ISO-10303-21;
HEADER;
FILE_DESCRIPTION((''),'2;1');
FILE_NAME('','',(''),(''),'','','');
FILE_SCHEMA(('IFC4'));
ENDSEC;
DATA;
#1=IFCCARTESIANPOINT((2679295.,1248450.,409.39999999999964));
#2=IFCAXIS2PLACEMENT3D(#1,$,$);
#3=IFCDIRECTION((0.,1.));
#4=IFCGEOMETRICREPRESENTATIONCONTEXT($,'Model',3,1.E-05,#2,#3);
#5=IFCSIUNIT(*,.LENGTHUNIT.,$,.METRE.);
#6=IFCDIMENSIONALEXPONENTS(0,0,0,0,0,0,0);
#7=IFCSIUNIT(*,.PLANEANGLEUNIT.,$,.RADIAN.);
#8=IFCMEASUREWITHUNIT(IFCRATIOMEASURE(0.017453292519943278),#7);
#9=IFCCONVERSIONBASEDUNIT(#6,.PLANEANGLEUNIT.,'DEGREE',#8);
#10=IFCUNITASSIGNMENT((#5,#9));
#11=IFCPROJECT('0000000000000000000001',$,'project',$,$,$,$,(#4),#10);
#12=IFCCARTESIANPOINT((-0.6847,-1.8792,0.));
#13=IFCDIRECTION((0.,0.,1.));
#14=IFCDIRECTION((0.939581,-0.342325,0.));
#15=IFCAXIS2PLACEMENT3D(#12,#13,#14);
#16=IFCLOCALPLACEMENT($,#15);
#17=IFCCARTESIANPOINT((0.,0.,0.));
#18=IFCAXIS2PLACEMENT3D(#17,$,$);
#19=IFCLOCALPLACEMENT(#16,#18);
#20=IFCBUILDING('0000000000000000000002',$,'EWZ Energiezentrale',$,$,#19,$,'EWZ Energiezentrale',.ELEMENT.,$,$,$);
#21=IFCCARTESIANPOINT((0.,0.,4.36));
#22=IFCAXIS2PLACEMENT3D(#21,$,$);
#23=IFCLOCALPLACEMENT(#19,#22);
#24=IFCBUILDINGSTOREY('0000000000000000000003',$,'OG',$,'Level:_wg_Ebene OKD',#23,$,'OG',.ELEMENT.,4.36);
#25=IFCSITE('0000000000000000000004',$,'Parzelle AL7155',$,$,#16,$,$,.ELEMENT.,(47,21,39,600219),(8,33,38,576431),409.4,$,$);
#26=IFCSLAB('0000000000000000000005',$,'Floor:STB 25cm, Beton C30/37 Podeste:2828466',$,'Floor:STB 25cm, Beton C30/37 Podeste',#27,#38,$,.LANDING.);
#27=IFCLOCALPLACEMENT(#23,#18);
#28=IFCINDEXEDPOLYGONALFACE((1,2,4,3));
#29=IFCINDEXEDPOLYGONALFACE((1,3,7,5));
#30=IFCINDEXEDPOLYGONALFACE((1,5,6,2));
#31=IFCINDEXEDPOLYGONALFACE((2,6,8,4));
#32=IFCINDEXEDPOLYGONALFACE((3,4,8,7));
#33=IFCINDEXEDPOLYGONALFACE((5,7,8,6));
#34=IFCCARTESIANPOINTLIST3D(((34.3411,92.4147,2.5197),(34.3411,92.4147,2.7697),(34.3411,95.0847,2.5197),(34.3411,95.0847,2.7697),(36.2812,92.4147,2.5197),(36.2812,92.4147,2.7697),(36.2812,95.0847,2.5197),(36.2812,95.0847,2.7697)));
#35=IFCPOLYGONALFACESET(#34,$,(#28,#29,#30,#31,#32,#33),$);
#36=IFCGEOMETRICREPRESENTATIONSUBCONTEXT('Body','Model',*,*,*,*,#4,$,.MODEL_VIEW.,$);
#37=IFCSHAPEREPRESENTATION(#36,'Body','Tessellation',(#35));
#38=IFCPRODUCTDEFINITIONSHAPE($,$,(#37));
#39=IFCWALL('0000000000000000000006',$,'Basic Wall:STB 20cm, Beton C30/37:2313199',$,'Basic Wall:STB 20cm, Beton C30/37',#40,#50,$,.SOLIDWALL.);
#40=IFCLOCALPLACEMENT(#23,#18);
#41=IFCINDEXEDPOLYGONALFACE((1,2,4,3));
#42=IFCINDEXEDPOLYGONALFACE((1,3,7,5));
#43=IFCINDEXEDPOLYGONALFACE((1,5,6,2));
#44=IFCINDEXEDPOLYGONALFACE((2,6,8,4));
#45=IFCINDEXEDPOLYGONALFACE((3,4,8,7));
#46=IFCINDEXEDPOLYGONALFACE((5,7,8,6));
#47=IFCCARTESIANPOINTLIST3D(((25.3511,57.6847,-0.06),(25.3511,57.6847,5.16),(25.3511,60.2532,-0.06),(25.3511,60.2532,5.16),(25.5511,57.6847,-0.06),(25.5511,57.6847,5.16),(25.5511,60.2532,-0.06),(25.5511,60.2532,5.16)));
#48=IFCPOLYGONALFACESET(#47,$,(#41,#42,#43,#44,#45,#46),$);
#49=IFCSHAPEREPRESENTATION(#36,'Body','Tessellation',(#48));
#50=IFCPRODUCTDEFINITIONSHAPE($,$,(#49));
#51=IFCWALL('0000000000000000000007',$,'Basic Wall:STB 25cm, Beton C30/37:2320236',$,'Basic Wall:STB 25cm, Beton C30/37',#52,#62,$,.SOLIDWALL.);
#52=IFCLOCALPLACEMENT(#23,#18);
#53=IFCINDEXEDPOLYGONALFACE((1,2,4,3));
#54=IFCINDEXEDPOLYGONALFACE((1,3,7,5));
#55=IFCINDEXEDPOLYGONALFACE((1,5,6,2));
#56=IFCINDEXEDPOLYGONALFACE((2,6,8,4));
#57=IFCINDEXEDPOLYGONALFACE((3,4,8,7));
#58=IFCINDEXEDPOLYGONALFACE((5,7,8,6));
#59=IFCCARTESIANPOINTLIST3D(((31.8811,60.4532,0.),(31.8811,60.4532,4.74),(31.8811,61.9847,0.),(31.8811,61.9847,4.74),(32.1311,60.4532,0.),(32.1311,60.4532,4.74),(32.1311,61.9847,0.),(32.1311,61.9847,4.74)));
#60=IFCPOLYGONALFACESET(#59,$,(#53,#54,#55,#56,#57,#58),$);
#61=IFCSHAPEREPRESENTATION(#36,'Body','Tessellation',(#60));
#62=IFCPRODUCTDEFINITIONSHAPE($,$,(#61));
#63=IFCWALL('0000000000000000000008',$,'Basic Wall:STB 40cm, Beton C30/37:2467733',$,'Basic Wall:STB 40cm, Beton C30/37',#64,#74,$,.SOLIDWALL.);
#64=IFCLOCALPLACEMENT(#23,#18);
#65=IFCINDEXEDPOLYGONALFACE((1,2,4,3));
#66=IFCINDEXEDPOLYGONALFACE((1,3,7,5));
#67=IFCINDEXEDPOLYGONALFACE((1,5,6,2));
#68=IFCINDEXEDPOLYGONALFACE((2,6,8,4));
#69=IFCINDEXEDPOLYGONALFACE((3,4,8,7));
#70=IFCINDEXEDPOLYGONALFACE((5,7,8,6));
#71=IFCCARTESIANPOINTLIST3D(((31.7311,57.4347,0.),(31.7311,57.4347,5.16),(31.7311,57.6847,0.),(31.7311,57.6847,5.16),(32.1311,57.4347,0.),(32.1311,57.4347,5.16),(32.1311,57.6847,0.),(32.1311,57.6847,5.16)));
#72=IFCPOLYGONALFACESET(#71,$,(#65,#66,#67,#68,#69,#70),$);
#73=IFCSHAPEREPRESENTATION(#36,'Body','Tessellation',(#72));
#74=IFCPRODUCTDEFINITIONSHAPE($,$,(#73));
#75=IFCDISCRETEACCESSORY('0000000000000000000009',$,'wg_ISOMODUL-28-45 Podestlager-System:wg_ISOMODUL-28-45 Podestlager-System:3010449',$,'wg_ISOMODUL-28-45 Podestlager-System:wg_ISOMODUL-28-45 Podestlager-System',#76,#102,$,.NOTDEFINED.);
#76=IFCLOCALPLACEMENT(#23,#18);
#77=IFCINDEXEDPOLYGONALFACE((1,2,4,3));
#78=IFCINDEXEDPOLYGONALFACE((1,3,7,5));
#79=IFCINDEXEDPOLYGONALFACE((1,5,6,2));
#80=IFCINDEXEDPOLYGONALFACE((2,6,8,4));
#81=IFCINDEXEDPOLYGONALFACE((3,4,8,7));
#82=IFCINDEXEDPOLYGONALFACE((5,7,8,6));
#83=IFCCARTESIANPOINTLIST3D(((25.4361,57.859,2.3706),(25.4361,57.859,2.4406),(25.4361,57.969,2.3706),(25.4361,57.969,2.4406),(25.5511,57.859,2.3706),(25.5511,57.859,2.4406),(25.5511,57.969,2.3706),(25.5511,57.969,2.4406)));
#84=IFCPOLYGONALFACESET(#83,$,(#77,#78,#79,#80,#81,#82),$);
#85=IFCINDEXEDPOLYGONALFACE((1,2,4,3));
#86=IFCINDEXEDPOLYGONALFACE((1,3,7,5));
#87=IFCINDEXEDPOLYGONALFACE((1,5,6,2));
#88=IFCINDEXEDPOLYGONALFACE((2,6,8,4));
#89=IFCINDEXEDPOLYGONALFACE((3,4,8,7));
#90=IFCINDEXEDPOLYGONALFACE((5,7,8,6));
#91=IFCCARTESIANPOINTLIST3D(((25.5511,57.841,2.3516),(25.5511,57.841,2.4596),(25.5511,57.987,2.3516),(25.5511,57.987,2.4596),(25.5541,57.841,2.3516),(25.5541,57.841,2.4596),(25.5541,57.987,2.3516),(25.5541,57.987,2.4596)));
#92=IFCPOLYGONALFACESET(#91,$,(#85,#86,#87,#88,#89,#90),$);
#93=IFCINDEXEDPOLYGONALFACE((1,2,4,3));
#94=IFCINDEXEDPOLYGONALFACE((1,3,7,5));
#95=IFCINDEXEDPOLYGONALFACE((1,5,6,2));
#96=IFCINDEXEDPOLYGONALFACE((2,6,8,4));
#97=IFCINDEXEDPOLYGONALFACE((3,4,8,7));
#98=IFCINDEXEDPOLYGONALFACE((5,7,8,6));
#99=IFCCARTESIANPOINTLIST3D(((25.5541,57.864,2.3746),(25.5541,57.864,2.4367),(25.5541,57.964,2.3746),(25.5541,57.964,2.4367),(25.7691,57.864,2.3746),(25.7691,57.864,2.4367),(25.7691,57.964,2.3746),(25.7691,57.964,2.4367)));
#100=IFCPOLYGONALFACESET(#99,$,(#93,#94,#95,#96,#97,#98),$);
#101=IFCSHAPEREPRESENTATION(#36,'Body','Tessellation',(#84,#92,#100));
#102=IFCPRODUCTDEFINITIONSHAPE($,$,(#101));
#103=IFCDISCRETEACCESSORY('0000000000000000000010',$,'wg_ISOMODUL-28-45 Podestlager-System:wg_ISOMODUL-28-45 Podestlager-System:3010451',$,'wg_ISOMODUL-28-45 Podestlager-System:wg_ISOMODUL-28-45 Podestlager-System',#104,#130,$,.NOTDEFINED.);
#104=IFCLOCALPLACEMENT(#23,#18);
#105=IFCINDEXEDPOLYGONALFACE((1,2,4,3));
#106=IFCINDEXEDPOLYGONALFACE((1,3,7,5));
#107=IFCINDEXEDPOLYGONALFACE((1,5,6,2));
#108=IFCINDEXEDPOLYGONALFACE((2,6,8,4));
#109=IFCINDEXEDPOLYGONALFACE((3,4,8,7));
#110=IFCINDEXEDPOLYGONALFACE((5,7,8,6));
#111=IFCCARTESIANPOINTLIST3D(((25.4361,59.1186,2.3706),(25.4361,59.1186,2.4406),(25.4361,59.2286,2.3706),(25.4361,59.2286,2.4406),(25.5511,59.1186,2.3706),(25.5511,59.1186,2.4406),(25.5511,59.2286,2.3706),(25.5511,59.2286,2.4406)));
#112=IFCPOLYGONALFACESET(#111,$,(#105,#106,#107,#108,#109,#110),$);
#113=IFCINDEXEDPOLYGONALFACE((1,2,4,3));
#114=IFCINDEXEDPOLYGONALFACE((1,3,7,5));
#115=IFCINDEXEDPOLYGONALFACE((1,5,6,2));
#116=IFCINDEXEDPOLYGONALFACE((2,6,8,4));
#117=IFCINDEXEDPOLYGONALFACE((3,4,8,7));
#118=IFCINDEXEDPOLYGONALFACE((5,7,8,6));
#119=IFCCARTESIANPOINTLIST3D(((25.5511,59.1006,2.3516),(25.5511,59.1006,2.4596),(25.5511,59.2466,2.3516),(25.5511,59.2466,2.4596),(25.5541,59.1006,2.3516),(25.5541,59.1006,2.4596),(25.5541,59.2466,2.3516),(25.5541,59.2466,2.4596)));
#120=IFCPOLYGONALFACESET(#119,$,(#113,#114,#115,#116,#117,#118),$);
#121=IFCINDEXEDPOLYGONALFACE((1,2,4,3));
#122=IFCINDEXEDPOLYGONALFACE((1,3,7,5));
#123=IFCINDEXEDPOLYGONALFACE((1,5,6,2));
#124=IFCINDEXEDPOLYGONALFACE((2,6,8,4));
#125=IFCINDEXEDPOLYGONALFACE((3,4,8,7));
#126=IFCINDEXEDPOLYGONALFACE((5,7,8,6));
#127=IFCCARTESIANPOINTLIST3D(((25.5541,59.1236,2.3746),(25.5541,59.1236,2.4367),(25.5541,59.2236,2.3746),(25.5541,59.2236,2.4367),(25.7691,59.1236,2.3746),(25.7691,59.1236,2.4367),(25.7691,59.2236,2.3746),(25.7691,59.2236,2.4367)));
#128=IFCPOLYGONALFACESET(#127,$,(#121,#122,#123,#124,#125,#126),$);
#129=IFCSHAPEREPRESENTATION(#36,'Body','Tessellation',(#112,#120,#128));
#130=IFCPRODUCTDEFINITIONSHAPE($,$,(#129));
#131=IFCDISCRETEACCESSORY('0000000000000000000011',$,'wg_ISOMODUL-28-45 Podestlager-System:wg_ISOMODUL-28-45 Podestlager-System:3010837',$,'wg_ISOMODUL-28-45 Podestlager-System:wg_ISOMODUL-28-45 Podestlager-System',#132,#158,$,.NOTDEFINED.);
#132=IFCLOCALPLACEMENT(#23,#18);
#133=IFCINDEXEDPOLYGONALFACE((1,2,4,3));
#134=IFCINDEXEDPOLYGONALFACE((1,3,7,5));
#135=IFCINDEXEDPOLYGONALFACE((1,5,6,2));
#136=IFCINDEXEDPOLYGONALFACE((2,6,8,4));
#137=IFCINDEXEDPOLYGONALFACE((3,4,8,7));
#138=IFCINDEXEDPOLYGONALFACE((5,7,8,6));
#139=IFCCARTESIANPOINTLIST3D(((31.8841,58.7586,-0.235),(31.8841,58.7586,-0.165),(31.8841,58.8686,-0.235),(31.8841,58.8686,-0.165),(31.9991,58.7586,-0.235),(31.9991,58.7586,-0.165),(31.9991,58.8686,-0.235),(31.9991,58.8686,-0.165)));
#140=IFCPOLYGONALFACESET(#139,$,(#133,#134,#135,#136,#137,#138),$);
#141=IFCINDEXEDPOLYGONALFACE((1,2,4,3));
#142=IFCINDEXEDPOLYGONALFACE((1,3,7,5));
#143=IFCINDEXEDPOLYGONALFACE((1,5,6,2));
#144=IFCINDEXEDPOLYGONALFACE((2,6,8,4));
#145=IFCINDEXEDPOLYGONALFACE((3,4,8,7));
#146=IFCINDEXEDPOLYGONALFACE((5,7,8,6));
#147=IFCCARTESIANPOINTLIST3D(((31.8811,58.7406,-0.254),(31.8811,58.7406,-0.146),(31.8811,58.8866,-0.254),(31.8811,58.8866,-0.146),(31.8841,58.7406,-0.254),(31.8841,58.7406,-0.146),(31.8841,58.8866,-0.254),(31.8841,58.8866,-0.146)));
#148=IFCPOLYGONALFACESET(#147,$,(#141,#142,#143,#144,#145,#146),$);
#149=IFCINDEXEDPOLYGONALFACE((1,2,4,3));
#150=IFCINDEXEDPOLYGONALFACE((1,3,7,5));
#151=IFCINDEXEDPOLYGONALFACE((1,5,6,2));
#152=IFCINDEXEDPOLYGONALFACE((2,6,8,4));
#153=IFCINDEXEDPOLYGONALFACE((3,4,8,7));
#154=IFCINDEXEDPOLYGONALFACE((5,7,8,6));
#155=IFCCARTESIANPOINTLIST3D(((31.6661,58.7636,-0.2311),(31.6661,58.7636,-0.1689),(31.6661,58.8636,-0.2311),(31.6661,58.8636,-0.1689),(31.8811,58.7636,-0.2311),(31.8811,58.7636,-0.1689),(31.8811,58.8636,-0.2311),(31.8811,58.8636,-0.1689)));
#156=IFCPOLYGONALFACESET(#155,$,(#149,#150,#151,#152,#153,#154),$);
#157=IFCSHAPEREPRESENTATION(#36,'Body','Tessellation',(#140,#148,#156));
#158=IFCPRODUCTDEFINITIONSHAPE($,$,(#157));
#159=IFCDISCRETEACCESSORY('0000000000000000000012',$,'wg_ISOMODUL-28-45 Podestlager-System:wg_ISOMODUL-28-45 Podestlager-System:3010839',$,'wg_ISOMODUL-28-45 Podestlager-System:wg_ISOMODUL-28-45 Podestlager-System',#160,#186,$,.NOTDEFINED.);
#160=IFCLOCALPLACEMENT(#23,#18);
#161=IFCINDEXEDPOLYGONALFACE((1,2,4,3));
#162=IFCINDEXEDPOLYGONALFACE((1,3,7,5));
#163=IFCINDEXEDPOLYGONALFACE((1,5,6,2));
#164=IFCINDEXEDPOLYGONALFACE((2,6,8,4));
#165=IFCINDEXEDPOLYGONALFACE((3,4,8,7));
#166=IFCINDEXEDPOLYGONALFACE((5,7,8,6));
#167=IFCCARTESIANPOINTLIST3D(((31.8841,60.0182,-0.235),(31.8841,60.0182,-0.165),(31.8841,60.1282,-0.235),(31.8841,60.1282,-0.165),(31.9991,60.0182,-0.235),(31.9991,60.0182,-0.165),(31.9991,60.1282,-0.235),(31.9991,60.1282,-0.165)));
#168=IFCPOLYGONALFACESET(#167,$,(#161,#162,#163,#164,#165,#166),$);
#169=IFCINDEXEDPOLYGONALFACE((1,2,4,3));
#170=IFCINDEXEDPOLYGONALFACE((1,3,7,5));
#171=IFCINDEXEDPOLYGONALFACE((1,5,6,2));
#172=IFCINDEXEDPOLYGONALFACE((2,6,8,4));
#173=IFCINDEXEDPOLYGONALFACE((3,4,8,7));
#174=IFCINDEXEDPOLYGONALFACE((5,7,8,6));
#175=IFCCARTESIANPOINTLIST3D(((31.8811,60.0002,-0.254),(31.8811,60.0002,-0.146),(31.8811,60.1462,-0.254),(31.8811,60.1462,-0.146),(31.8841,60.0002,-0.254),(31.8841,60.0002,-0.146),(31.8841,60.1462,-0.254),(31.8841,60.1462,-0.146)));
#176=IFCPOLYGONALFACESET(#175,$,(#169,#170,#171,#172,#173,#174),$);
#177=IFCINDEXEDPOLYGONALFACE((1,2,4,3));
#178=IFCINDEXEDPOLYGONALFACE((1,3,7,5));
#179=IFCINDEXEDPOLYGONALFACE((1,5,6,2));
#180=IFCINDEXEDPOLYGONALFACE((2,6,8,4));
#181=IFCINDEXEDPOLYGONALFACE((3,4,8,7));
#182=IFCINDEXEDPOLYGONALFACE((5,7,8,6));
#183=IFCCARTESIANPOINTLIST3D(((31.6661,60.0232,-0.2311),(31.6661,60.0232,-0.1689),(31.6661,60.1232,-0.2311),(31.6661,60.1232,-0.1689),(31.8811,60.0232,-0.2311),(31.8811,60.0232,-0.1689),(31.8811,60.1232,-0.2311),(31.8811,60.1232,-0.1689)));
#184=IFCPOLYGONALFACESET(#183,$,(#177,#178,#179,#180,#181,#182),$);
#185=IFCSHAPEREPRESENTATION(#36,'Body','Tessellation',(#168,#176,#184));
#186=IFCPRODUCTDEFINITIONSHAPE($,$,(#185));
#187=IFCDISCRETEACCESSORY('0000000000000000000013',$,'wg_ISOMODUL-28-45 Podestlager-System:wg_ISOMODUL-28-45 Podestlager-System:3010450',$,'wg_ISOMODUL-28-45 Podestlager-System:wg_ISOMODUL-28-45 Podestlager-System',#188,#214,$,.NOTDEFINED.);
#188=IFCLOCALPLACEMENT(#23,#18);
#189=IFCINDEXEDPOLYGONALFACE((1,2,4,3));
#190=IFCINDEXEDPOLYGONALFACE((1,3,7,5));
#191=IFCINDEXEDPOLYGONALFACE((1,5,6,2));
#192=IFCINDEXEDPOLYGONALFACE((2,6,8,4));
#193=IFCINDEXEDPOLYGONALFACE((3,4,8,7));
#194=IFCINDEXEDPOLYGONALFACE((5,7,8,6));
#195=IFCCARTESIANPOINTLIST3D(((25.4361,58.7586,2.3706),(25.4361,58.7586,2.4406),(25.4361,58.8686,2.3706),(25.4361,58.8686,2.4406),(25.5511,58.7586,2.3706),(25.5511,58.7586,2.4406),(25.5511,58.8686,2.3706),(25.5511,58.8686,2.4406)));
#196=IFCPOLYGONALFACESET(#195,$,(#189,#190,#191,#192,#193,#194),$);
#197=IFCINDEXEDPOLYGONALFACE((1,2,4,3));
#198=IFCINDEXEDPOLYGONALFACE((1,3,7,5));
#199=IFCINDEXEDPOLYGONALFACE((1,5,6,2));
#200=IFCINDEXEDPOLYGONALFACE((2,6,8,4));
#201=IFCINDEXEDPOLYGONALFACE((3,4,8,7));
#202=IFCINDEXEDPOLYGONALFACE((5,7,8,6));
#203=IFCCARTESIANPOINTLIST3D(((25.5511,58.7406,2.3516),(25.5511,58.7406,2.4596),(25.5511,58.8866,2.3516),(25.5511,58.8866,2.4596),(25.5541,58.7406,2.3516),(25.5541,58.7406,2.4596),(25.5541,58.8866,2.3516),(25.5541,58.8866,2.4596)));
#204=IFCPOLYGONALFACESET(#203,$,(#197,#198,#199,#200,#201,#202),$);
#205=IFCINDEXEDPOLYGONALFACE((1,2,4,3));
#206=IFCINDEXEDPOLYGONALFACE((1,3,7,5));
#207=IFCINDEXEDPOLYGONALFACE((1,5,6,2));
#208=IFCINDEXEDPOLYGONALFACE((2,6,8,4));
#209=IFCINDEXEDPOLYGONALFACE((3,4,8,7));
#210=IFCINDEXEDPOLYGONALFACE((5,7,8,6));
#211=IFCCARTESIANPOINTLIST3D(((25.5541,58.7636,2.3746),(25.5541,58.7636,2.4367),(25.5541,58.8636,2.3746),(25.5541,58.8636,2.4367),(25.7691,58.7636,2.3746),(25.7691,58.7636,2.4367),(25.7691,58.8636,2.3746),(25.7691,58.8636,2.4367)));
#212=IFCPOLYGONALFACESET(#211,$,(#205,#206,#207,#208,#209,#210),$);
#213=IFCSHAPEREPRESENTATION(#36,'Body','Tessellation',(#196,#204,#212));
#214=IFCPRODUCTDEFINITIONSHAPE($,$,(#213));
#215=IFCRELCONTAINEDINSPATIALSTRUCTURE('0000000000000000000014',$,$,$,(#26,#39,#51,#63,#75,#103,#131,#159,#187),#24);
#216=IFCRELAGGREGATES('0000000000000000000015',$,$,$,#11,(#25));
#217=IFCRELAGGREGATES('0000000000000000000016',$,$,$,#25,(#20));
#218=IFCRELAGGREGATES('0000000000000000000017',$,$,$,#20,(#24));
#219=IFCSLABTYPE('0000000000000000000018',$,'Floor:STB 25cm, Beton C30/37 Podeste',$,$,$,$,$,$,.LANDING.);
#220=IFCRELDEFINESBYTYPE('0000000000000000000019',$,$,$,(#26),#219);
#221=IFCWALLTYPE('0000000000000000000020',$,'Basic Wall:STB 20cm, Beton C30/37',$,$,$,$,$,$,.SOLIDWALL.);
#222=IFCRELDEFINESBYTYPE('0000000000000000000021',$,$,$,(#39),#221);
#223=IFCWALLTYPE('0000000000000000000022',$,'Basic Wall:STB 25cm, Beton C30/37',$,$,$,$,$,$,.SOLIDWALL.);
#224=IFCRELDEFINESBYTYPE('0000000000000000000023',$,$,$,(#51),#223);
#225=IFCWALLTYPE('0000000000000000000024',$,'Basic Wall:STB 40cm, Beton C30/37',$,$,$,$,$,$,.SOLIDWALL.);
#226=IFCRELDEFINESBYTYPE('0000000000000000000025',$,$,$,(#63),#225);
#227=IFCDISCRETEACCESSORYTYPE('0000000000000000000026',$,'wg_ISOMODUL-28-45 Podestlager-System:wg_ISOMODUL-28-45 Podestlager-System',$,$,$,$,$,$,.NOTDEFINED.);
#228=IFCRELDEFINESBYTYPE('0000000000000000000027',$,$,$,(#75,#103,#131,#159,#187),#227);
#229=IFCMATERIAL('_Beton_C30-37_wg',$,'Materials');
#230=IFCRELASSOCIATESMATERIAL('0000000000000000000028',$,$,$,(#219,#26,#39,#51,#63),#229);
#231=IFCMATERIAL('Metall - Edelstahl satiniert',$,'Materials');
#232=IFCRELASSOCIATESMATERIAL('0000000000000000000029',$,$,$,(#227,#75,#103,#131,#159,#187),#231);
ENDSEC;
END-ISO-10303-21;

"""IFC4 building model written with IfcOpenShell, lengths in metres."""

from ifc_helpers import new_model, entity, si_unit, converted_unit, direction, frame, origin, place, context, subcontext, project, spatial, indexed_curve, outline, extrude, source, transform, mapped, material, type_object, type_shapes, element, save


model = new_model("IFC4")

# Units and contexts
model_context = context("Model", 3, precision=1e-05, world=frame((2679295.0, 1248450.0, 409.39999999999964)), true_north=direction((0.0, 1.0)))
body_context = subcontext(model_context, "Body", "Model", "MODEL_VIEW")
ifc_project = project(units=[si_unit("LENGTHUNIT", "METRE"), converted_unit("PLANEANGLEUNIT", "DEGREE", entity("IfcRatioMeasure", 0.017453292519943278), si_unit("PLANEANGLEUNIT", "RADIAN"), dimensions=[0, 0, 0, 0, 0, 0, 0])], contexts=[model_context])

# Site, building, storey
site_placement = place(None, frame((-0.6847, -1.8792, 0.0), z_axis=(0.0, 0.0, 1.0), x_axis=(0.939581, -0.342325, 0.0)))
site = spatial("IfcSite", under=ifc_project, at=site_placement, Name="Parzelle AL7155", CompositionType="ELEMENT", RefLatitude=(47, 21, 39, 600219), RefLongitude=(8, 33, 38, 576431), RefElevation=409.4)
building_placement = place(site_placement, origin())
building = spatial("IfcBuilding", under=site, at=building_placement, Name="EWZ Energiezentrale", LongName="EWZ Energiezentrale", CompositionType="ELEMENT")
storey_placement = place(building_placement, frame((0.0, 0.0, 4.36)))
storey = spatial("IfcBuildingStorey", under=building, at=storey_placement, Name="OG", ObjectType="Level:_wg_Ebene OKD", LongName="OG", CompositionType="ELEMENT", Elevation=4.36)

# Slab
ifc_material_1 = material(Name="_Beton_C30-37_wg", Category="Materials")
slab_type = type_object("IfcSlabType", Name="Floor:STB 25cm, Beton C30/37 Podeste", PredefinedType="LANDING", material=ifc_material_1)
slab_placement = place(storey_placement, frame((0.0, 0.0, 0.0), z_axis=(0.0, 0.0, 1.0), x_axis=(1.0, 0.0, 0.0)))
element("IfcSlab", 1, at=slab_placement, inside=storey, type_object=slab_type, material=ifc_material_1, Name="Floor:STB 25cm, Beton C30/37 Podeste:2828466", ObjectType="Floor:STB 25cm, Beton C30/37 Podeste", PredefinedType="LANDING", context=body_context, shape_type="SweptSolid", body=[
    extrude(outline(indexed_curve([(-1.335, -0.9701), (1.335, -0.9701), (1.335, 0.9701), (-1.335, 0.9701), (-1.335, -0.9701)], self_intersect=False)), frame((35.3111, 93.7497, 2.7697), z_axis=(0.0, 0.0, -1.0), x_axis=(0.0, 1.0, 0.0)), (0.0, 0.0, 1.0), 0.25),
])

# Walls
wall_type_1 = type_object("IfcWallType", Name="Basic Wall:STB 20cm, Beton C30/37", PredefinedType="SOLIDWALL")
wall_1_placement = place(storey_placement, frame((25.4511, 57.6847, -0.06), z_axis=(0.0, 0.0, 1.0), x_axis=(0.0, 1.0, 0.0)))
element("IfcWall", 2, at=wall_1_placement, inside=storey, type_object=wall_type_1, material=ifc_material_1, Name="Basic Wall:STB 20cm, Beton C30/37:2313199", ObjectType="Basic Wall:STB 20cm, Beton C30/37", PredefinedType="SOLIDWALL", context=body_context, shape_type="SweptSolid", body=[
    extrude(outline(indexed_curve([(2.5686, 0.1), (0.0, 0.1), (0.0, -0.1), (2.5686, -0.1), (2.5686, 0.1)], self_intersect=False)), origin(), (0.0, 0.0, 1.0), 5.22),
])
wall_type_2 = type_object("IfcWallType", Name="Basic Wall:STB 25cm, Beton C30/37", PredefinedType="SOLIDWALL")
wall_2_placement = place(storey_placement, frame((32.0061, 60.4532, 0.0), z_axis=(0.0, 0.0, 1.0), x_axis=(0.0, 1.0, 0.0)))
element("IfcWall", 3, at=wall_2_placement, inside=storey, type_object=wall_type_2, material=ifc_material_1, Name="Basic Wall:STB 25cm, Beton C30/37:2320236", ObjectType="Basic Wall:STB 25cm, Beton C30/37", PredefinedType="SOLIDWALL", context=body_context, shape_type="SweptSolid", body=[
    extrude(outline(indexed_curve([(1.5314, 0.125), (0.0, 0.125), (0.0, -0.125), (1.5314, -0.125), (1.5314, 0.125)], self_intersect=False)), origin(), (0.0, 0.0, 1.0), 4.74),
])
wall_type_3 = type_object("IfcWallType", Name="Basic Wall:STB 40cm, Beton C30/37", PredefinedType="SOLIDWALL")
wall_3_placement = place(storey_placement, frame((31.9311, 57.4347, 0.0), z_axis=(0.0, 0.0, 1.0), x_axis=(0.0, 1.0, 0.0)))
element("IfcWall", 4, at=wall_3_placement, inside=storey, type_object=wall_type_3, material=ifc_material_1, Name="Basic Wall:STB 40cm, Beton C30/37:2467733", ObjectType="Basic Wall:STB 40cm, Beton C30/37", PredefinedType="SOLIDWALL", context=body_context, shape_type="SweptSolid", body=[
    extrude(outline(indexed_curve([(0.25, 0.2), (0.0, 0.2), (0.0, -0.2), (0.25, -0.2), (0.25, 0.2)], self_intersect=False)), origin(), (0.0, 0.0, 1.0), 5.16),
])

# Discrete accessories
ifc_material_2 = material(Name="Metall - Edelstahl satiniert", Category="Materials")
discrete_accessory_type_1 = type_object("IfcDiscreteAccessoryType", Name="wg_ISOMODUL-28-45 Podestlager-System:wg_ISOMODUL-28-45 Podestlager-System", PredefinedType="NOTDEFINED", material=ifc_material_2)
shared_shape_1 = source(origin(), body_context, "Body", "SweptSolid", [
    extrude(outline(indexed_curve([(-0.055, -0.0575), (0.055, -0.0575), (0.055, 0.0575), (-0.055, 0.0575), (-0.055, -0.0575)], self_intersect=False)), frame((0.0, -0.0575, 0.0), z_axis=(0.0, 0.0, 1.0), x_axis=(-1.0, 0.0, 0.0)), (0.0, 0.0, 1.0), 0.07),
    extrude(outline(indexed_curve([(-0.073, -0.0015), (0.073, -0.0015), (0.073, 0.0015), (-0.073, 0.0015), (-0.073, -0.0015)], self_intersect=False)), frame((0.0, 0.0015, -0.019), z_axis=(0.0, 0.0, 1.0), x_axis=(-1.0, 0.0, 0.0)), (0.0, 0.0, 1.0), 0.108),
    extrude(outline(indexed_curve([(-0.05, -0.1075), (0.05, -0.1075), (0.05, 0.1075), (-0.05, 0.1075), (-0.05, -0.1075)], self_intersect=False)), frame((0.0, 0.1105, 0.0039), z_axis=(0.0, 0.0, 1.0), x_axis=(-1.0, 0.0, 0.0)), (0.0, 0.0, 1.0), 0.0621),
])
type_shapes(discrete_accessory_type_1, [shared_shape_1])
for number, where, z_axis, x_axis, name in (
    (5, (25.5511, 57.914, 2.3706), (0.0, 0.0, 1.0), (0.0, -1.0, 0.0), "wg_ISOMODUL-28-45 Podestlager-System:wg_ISOMODUL-28-45 Podestlager-System:3010449"),
    (6, (25.5511, 59.1736, 2.3706), (0.0, 0.0, 1.0), (0.0, -1.0, 0.0), "wg_ISOMODUL-28-45 Podestlager-System:wg_ISOMODUL-28-45 Podestlager-System:3010451"),
    (7, (31.8841, 58.8136, -0.235), (0.0, 0.0, 1.0), (0.0, 1.0, 0.0), "wg_ISOMODUL-28-45 Podestlager-System:wg_ISOMODUL-28-45 Podestlager-System:3010837"),
    (8, (31.8841, 60.0732, -0.235), (0.0, 0.0, 1.0), (0.0, 1.0, 0.0), "wg_ISOMODUL-28-45 Podestlager-System:wg_ISOMODUL-28-45 Podestlager-System:3010839"),
):
    element("IfcDiscreteAccessory", number, at=place(storey_placement, frame(where, z_axis=z_axis, x_axis=x_axis)), inside=storey, type_object=discrete_accessory_type_1, material=ifc_material_2, Name=name, ObjectType="wg_ISOMODUL-28-45 Podestlager-System:wg_ISOMODUL-28-45 Podestlager-System", PredefinedType="NOTDEFINED", context=body_context, shape_type="MappedRepresentation", body=[
        mapped(shared_shape_1, transform((0.0, 0.0, 0.0), scale=1.0)),
    ])
shared_shape_2 = source(origin(), body_context, "Body", "SweptSolid", [
    extrude(outline(indexed_curve([(-0.0575, -0.055), (0.0575, -0.055), (0.0575, 0.055), (-0.0575, 0.055), (-0.0575, -0.055)], self_intersect=False)), frame((0.0, 0.0575, 0.0), z_axis=(0.0, 0.0, 1.0), x_axis=(0.0, 1.0, 0.0)), (0.0, 0.0, 1.0), 0.07),
    extrude(outline(indexed_curve([(-0.0015, -0.073), (0.0015, -0.073), (0.0015, 0.073), (-0.0015, 0.073), (-0.0015, -0.073)], self_intersect=False)), frame((0.0, -0.0015, -0.019), z_axis=(0.0, 0.0, 1.0), x_axis=(0.0, 1.0, 0.0)), (0.0, 0.0, 1.0), 0.108),
    extrude(outline(indexed_curve([(-0.1075, -0.05), (0.1075, -0.05), (0.1075, 0.05), (-0.1075, 0.05), (-0.1075, -0.05)], self_intersect=False)), frame((0.0, -0.1105, 0.0039), z_axis=(0.0, 0.0, 1.0), x_axis=(0.0, 1.0, 0.0)), (0.0, 0.0, 1.0), 0.0621),
])
for number, where, z_axis, x_axis, name in (
    (9, (25.5511, 58.8136, 2.3706), (0.0, 0.0, 1.0), (0.0, 1.0, 0.0), "wg_ISOMODUL-28-45 Podestlager-System:wg_ISOMODUL-28-45 Podestlager-System:3010450"),
):
    element("IfcDiscreteAccessory", number, at=place(storey_placement, frame(where, z_axis=z_axis, x_axis=x_axis)), inside=storey, type_object=discrete_accessory_type_1, material=ifc_material_2, Name=name, ObjectType="wg_ISOMODUL-28-45 Podestlager-System:wg_ISOMODUL-28-45 Podestlager-System", PredefinedType="NOTDEFINED", context=body_context, shape_type="MappedRepresentation", body=[
        mapped(shared_shape_2, transform((0.0, 0.0, 0.0), scale=1.0)),
    ])

save(model, "model.ifc")
